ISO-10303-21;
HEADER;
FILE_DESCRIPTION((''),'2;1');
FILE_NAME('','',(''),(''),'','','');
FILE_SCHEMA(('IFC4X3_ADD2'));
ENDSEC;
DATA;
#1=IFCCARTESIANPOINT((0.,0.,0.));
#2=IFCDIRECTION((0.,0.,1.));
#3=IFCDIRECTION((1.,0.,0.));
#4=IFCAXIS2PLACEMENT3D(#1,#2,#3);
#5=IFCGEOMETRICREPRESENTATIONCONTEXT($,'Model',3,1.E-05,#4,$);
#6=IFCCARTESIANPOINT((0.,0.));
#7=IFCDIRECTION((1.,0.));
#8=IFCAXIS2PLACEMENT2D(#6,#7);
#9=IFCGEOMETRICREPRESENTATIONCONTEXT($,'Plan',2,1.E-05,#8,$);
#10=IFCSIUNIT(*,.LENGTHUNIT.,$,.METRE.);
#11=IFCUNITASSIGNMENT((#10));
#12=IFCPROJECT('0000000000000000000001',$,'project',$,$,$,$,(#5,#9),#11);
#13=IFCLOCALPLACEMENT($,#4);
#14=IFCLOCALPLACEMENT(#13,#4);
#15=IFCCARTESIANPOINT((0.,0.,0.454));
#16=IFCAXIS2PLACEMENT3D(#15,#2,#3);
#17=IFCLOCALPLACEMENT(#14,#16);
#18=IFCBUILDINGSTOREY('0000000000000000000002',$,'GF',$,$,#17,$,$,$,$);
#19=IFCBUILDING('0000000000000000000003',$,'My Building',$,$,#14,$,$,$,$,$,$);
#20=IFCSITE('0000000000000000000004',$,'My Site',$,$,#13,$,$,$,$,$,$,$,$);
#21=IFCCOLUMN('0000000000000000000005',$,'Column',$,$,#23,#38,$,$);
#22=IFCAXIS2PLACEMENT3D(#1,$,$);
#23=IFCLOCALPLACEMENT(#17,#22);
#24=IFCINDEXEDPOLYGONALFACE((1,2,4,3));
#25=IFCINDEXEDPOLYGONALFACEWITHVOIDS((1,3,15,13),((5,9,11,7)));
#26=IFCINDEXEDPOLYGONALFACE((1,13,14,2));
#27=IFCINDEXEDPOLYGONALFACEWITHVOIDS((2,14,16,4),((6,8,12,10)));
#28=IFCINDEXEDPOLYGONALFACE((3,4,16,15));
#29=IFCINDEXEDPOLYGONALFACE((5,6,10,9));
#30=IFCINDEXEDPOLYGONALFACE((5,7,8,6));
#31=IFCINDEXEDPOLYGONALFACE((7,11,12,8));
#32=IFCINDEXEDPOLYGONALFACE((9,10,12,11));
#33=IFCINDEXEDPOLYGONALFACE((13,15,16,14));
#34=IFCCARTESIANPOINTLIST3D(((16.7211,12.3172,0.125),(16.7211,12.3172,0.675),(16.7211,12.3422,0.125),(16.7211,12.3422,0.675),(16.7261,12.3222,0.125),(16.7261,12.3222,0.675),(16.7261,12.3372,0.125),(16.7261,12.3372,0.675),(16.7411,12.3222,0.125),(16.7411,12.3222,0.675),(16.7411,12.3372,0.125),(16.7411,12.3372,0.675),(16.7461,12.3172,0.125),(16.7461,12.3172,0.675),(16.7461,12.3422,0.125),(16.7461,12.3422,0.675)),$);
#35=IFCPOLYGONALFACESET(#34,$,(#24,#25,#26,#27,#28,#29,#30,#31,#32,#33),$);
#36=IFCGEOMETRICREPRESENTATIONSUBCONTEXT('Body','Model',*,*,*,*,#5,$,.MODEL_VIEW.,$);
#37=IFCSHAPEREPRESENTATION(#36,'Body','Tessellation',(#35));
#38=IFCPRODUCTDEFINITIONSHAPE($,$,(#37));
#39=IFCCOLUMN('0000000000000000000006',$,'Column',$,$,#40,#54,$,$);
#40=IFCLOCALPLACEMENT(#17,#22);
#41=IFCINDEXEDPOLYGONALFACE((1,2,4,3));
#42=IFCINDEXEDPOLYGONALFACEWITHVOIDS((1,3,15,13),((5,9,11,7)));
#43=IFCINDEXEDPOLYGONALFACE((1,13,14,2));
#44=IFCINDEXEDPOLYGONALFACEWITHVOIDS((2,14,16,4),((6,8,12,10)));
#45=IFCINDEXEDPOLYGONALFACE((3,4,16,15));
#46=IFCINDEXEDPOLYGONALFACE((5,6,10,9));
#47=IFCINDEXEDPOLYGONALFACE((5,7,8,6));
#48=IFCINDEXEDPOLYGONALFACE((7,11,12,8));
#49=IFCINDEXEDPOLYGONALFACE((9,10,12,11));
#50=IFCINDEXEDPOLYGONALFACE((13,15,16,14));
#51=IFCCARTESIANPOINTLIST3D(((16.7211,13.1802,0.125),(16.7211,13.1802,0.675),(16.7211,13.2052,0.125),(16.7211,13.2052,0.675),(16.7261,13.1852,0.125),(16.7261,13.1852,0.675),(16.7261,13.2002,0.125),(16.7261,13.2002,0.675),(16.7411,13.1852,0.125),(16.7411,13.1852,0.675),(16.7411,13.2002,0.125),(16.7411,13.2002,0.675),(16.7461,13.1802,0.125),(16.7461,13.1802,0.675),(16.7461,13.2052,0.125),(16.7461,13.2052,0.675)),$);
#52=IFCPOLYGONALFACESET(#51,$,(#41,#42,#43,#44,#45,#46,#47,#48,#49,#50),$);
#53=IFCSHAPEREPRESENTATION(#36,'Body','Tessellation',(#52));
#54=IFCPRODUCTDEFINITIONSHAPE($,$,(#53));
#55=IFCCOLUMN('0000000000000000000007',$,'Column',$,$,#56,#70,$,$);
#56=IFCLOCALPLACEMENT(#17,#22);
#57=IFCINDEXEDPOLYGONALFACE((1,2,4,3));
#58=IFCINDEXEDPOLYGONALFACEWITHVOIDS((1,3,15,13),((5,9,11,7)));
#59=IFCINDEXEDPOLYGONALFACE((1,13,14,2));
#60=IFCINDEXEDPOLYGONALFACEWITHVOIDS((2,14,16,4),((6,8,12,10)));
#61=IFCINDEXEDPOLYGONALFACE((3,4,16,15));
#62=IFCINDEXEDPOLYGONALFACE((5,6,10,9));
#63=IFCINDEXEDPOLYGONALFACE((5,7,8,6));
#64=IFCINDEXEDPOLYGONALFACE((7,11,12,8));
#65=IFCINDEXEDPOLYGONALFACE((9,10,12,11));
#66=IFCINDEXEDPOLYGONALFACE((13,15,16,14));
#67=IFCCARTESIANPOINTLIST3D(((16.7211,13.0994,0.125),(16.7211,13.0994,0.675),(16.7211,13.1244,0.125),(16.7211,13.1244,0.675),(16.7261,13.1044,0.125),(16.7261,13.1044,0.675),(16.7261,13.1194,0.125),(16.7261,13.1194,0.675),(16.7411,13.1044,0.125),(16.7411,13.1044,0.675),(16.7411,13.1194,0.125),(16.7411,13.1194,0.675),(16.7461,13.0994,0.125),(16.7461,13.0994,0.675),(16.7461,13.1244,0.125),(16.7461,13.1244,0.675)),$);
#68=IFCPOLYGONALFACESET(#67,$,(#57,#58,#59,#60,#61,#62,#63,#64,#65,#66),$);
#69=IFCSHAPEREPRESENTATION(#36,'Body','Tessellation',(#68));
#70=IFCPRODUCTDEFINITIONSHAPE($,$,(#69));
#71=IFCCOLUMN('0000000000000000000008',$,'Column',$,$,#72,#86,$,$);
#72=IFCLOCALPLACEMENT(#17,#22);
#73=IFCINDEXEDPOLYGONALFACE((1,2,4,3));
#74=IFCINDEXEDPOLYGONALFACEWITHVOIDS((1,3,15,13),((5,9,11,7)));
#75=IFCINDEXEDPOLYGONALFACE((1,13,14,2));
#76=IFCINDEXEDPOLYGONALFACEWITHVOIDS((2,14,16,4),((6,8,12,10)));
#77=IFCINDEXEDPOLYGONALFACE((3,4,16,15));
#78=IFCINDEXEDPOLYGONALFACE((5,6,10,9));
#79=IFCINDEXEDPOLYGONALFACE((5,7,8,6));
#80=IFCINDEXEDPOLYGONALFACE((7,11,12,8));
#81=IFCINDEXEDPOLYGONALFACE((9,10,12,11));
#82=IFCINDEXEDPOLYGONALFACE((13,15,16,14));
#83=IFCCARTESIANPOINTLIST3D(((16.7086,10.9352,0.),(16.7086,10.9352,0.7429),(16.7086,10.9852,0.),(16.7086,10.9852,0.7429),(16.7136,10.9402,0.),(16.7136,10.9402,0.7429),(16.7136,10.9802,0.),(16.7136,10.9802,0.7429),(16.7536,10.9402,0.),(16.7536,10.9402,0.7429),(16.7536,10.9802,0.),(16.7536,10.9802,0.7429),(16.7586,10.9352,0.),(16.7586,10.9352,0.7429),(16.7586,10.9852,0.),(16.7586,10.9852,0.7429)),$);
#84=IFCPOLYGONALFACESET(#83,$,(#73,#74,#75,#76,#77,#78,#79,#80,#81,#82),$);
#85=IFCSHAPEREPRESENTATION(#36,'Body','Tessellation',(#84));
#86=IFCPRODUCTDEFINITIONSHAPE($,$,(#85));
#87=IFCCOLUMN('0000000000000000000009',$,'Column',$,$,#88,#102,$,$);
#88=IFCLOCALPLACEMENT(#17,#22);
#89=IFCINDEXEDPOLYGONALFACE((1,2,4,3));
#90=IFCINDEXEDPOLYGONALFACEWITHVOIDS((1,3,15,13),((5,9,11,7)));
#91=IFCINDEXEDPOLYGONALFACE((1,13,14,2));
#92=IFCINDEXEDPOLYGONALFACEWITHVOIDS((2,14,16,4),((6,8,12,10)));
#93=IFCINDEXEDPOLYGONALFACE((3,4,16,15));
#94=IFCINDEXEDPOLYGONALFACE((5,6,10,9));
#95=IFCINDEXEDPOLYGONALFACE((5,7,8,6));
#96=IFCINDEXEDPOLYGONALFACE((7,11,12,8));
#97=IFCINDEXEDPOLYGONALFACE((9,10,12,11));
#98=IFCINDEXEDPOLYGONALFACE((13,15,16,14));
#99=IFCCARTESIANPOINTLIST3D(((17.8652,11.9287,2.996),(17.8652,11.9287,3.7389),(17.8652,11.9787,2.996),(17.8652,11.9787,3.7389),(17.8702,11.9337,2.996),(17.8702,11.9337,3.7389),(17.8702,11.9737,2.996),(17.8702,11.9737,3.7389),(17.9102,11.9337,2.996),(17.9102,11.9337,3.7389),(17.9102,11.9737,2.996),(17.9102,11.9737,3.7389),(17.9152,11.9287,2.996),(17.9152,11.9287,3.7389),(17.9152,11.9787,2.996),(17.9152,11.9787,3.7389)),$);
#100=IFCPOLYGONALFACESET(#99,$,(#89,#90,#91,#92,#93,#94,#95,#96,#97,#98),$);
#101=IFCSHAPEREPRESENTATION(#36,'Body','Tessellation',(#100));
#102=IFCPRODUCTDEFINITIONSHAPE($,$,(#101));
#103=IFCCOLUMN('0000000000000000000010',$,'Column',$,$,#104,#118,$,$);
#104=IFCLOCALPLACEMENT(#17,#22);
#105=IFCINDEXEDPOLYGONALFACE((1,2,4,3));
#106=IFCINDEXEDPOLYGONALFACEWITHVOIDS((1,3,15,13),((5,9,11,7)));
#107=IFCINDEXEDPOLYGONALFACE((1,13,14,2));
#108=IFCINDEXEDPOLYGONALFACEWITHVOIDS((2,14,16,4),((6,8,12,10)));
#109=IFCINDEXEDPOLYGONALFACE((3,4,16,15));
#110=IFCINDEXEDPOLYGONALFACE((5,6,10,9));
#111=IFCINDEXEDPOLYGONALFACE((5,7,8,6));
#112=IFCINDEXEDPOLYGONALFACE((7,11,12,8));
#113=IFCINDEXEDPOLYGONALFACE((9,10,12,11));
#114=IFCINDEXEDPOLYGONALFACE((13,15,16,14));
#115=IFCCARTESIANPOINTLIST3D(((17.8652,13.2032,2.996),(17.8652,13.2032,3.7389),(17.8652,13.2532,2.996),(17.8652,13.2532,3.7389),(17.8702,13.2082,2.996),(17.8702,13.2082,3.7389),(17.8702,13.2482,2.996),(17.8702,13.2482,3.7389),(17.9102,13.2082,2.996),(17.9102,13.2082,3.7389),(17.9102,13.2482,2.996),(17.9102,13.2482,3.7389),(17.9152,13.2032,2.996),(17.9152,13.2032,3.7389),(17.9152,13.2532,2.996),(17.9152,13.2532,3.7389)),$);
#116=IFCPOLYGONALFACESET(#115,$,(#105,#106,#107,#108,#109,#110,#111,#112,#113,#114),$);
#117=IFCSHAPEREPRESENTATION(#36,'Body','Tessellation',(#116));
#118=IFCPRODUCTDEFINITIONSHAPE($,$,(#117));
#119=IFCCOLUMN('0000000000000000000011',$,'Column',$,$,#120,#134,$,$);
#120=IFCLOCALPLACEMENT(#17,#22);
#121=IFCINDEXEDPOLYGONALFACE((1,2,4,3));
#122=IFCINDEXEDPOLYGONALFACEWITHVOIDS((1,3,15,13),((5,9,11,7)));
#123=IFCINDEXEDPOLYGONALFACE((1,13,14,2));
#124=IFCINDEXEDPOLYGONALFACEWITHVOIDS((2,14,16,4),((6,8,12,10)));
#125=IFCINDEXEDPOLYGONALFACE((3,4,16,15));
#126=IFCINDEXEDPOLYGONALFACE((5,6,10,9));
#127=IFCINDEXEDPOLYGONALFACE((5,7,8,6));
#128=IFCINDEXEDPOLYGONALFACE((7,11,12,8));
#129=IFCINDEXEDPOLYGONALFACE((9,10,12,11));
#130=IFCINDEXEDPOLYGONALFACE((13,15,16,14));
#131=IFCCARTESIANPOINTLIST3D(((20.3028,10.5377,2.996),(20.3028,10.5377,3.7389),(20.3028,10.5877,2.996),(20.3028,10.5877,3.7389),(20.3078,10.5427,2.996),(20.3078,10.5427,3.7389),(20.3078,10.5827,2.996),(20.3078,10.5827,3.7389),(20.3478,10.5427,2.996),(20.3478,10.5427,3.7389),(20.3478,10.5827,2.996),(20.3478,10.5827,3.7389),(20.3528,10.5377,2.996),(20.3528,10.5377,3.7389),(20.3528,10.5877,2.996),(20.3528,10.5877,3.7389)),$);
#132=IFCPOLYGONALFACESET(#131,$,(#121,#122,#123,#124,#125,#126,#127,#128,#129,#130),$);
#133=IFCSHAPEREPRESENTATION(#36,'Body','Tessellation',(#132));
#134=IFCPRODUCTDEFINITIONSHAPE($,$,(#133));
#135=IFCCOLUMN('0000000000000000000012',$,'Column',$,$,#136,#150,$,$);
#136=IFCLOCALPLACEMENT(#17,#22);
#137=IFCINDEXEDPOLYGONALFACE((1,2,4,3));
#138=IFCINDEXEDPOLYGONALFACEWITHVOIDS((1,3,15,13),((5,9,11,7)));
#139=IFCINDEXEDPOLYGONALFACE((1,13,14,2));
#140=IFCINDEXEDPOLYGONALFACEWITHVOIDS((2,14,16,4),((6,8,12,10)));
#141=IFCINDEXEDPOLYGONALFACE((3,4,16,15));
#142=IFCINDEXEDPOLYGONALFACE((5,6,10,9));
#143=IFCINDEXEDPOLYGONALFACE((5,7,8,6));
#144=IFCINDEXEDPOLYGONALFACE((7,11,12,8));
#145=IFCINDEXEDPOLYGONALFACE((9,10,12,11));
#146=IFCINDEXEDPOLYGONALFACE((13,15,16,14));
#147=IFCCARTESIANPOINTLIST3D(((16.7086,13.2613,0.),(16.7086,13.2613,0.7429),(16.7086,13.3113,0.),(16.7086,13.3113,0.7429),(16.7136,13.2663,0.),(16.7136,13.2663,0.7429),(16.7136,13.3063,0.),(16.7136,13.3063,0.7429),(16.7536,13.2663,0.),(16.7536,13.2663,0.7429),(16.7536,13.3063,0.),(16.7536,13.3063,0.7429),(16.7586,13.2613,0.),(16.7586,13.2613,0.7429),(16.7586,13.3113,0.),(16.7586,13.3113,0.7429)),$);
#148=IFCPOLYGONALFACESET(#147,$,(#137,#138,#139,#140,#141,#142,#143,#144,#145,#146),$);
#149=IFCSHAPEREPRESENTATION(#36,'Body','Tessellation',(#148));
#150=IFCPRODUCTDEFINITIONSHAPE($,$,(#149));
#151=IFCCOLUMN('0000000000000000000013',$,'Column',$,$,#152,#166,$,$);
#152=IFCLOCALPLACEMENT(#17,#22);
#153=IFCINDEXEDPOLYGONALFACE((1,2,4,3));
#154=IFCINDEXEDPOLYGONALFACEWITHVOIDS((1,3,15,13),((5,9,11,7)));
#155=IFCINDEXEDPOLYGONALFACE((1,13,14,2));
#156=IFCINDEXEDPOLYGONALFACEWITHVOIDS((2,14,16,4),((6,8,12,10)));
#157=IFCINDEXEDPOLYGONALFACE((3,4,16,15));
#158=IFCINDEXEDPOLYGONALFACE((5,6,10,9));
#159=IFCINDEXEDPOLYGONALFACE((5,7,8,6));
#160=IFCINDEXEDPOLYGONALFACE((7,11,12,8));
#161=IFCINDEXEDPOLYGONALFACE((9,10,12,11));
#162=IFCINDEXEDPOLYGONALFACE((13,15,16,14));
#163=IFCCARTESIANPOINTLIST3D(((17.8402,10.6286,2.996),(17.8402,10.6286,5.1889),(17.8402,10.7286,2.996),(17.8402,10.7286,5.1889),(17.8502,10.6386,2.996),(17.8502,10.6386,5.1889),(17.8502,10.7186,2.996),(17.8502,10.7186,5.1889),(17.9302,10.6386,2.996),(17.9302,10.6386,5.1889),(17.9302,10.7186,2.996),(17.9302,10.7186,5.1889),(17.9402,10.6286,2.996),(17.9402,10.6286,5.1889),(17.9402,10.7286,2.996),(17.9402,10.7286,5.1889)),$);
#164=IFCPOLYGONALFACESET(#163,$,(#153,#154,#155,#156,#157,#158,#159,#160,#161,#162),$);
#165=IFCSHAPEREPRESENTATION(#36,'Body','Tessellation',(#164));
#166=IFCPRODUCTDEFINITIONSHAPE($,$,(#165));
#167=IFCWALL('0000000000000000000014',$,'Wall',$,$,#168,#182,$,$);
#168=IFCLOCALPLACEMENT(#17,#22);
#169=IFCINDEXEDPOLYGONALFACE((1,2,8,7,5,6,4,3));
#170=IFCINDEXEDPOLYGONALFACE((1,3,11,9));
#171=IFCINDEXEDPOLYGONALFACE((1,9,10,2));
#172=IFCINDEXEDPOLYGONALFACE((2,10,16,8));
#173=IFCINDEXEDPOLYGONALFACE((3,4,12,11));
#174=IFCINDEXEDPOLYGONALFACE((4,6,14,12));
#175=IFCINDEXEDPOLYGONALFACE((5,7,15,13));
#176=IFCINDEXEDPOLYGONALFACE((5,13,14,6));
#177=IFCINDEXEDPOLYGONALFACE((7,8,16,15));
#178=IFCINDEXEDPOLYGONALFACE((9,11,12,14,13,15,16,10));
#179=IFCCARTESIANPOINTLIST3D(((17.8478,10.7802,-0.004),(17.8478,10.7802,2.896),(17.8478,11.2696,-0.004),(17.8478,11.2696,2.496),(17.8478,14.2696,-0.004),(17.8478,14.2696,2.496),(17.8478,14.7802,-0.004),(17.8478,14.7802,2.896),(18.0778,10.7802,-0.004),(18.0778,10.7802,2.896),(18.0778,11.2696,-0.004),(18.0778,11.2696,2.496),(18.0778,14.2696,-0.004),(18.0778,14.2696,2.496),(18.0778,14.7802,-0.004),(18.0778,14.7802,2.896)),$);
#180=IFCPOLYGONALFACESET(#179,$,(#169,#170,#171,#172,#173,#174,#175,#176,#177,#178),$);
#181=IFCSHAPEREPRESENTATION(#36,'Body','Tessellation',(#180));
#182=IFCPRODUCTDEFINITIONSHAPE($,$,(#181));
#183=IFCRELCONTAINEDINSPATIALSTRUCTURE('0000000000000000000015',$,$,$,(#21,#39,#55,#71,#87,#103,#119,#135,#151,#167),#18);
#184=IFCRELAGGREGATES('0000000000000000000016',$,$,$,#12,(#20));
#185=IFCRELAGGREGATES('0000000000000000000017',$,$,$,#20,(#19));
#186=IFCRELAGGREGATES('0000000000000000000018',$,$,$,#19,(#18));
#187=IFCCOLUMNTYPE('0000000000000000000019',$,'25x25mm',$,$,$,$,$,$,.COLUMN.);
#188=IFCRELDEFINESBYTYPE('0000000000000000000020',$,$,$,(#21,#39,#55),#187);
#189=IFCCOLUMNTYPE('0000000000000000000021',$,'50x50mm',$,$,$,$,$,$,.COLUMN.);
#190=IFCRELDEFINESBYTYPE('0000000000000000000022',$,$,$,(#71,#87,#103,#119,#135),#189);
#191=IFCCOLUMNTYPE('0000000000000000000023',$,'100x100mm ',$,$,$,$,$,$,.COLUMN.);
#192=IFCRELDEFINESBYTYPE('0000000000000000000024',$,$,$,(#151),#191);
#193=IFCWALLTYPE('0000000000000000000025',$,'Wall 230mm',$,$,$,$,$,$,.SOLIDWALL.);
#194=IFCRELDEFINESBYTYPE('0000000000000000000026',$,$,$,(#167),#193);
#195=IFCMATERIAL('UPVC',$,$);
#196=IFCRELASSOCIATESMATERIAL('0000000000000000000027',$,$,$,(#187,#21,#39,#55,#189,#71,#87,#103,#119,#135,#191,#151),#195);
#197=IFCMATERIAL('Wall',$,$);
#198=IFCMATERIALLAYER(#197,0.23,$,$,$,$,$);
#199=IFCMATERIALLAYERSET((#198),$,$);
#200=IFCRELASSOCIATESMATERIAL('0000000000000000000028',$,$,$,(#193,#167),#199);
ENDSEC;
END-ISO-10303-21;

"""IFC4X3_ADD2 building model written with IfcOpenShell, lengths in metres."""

from ifc_helpers import new_model, si_unit, frame, origin_with_axes, origin_2d_with_axis, place, context, subcontext, project, spatial, line, indexed_curve, hollow_rectangle, outline, extrude, source, transform, mapped, material, layer, layer_set, layer_usage, material_profile, profile_set, profile_usage, type_object, element, save


model = new_model("IFC4X3_ADD2")

# Units and contexts
model_context = context("Model", 3, precision=1e-05, world=origin_with_axes())
plan_context = context("Plan", 2, precision=1e-05, world=origin_2d_with_axis())
body_context = subcontext(model_context, "Body", "Model", "MODEL_VIEW")
ifc_project = project(units=[si_unit("LENGTHUNIT", "METRE")], contexts=[model_context, plan_context])

# Site, building, storey
site_placement = place(None, origin_with_axes())
site = spatial("IfcSite", under=ifc_project, at=site_placement, Name="My Site")
building_placement = place(site_placement, origin_with_axes())
building = spatial("IfcBuilding", under=site, at=building_placement, Name="My Building")
storey_placement = place(building_placement, frame((0.0, 0.0, 0.454), z_axis=(0.0, 0.0, 1.0), x_axis=(1.0, 0.0, 0.0)))
storey = spatial("IfcBuildingStorey", under=building, at=storey_placement, Name="GF")

# Columns
ifc_material_1 = material(Name="UPVC")
ifc_material_profile_1 = material_profile(ifc_material_1, hollow_rectangle(XDim=0.025, YDim=0.025, WallThickness=0.005))
ifc_profile_set_1 = profile_set([ifc_material_profile_1])
column_type_1 = type_object("IfcColumnType", Name="25x25mm", PredefinedType="COLUMN", material=ifc_profile_set_1)
ifc_profile_usage_1 = profile_usage(ifc_profile_set_1)
column_1_placement = place(storey_placement, frame((16.7336, 12.3297, 0.125), z_axis=(0.0, 0.0, 1.0), x_axis=(0.0, -1.0, 0.0)))
element("IfcColumn", 1, at=column_1_placement, inside=storey, type_object=column_type_1, material=ifc_profile_usage_1, Name="Column", context=body_context, shape_type="SweptSolid", body=[
    extrude(hollow_rectangle(XDim=0.025, YDim=0.025, WallThickness=0.005), origin_with_axes(), (0.0, 0.0, 1.0), 0.55),
])
ifc_profile_usage_2 = profile_usage(ifc_profile_set_1)
column_2_placement = place(storey_placement, frame((16.7336, 13.1927, 0.125), z_axis=(0.0, 0.0, 1.0), x_axis=(0.0, -1.0, 0.0)))
element("IfcColumn", 2, at=column_2_placement, inside=storey, type_object=column_type_1, material=ifc_profile_usage_2, Name="Column", context=body_context, shape_type="SweptSolid", body=[
    extrude(hollow_rectangle(XDim=0.025, YDim=0.025, WallThickness=0.005), origin_with_axes(), (0.0, 0.0, 1.0), 0.55),
])
ifc_profile_usage_3 = profile_usage(ifc_profile_set_1)
column_3_placement = place(storey_placement, frame((16.7336, 13.1119, 0.125), z_axis=(0.0, 0.0, 1.0), x_axis=(0.0, -1.0, 0.0)))
element("IfcColumn", 3, at=column_3_placement, inside=storey, type_object=column_type_1, material=ifc_profile_usage_3, Name="Column", context=body_context, shape_type="SweptSolid", body=[
    extrude(hollow_rectangle(XDim=0.025, YDim=0.025, WallThickness=0.005), origin_with_axes(), (0.0, 0.0, 1.0), 0.55),
])
ifc_material_profile_2 = material_profile(ifc_material_1, hollow_rectangle(XDim=0.05, YDim=0.05, WallThickness=0.005))
ifc_profile_set_2 = profile_set([ifc_material_profile_2])
ifc_profile_usage_4 = profile_usage(ifc_profile_set_2)
column_type_2 = type_object("IfcColumnType", Name="50x50mm", PredefinedType="COLUMN", material=ifc_profile_set_2)
column_4_placement = place(storey_placement, frame((16.7336, 10.9602, 0.0), z_axis=(0.0, 0.0, 1.0), x_axis=(0.0, -1.0, 0.0)))
element("IfcColumn", 4, at=column_4_placement, inside=storey, type_object=column_type_2, material=ifc_profile_usage_4, Name="Column", context=body_context, shape_type="SweptSolid", body=[
    extrude(hollow_rectangle(XDim=0.05, YDim=0.05, WallThickness=0.005), origin_with_axes(), (0.0, 0.0, 1.0), 0.7429),
])
ifc_profile_usage_5 = profile_usage(ifc_profile_set_2)
column_5_placement = place(storey_placement, frame((17.8902, 11.9537, 2.996), z_axis=(0.0, 0.0, 1.0), x_axis=(0.0, -1.0, 0.0)))
element("IfcColumn", 5, at=column_5_placement, inside=storey, type_object=column_type_2, material=ifc_profile_usage_5, Name="Column", context=body_context, shape_type="SweptSolid", body=[
    extrude(hollow_rectangle(XDim=0.05, YDim=0.05, WallThickness=0.005), origin_with_axes(), (0.0, 0.0, 1.0), 0.7429),
])
ifc_profile_usage_6 = profile_usage(ifc_profile_set_2)
column_6_placement = place(storey_placement, frame((17.8902, 13.2282, 2.996), z_axis=(0.0, 0.0, 1.0), x_axis=(0.0, -1.0, 0.0)))
element("IfcColumn", 6, at=column_6_placement, inside=storey, type_object=column_type_2, material=ifc_profile_usage_6, Name="Column", context=body_context, shape_type="SweptSolid", body=[
    extrude(hollow_rectangle(XDim=0.05, YDim=0.05, WallThickness=0.005), origin_with_axes(), (0.0, 0.0, 1.0), 0.7429),
])
ifc_profile_usage_7 = profile_usage(ifc_profile_set_2)
column_7_placement = place(storey_placement, frame((20.3278, 10.5627, 2.996), z_axis=(0.0, 0.0, 1.0), x_axis=(1.0, 0.0, 0.0)))
element("IfcColumn", 7, at=column_7_placement, inside=storey, type_object=column_type_2, material=ifc_profile_usage_7, Name="Column", context=body_context, shape_type="SweptSolid", body=[
    extrude(hollow_rectangle(XDim=0.05, YDim=0.05, WallThickness=0.005), origin_with_axes(), (0.0, 0.0, 1.0), 0.7429),
])
ifc_profile_usage_8 = profile_usage(ifc_profile_set_2)
column_8_placement = place(storey_placement, frame((16.7336, 13.2863, 0.0), z_axis=(0.0, 0.0, 1.0), x_axis=(0.0, -1.0, 0.0)))
element("IfcColumn", 8, at=column_8_placement, inside=storey, type_object=column_type_2, material=ifc_profile_usage_8, Name="Column", context=body_context, shape_type="SweptSolid", body=[
    extrude(hollow_rectangle(XDim=0.05, YDim=0.05, WallThickness=0.005), origin_with_axes(), (0.0, 0.0, 1.0), 0.7429),
])
ifc_material_profile_3 = material_profile(ifc_material_1, hollow_rectangle(XDim=0.1, YDim=0.1, WallThickness=0.01))
ifc_profile_set_3 = profile_set([ifc_material_profile_3])
ifc_profile_usage_9 = profile_usage(ifc_profile_set_3)
column_type_3 = type_object("IfcColumnType", Name="100x100mm ", PredefinedType="COLUMN", material=ifc_profile_set_3)
column_9_placement = place(storey_placement, frame((17.8902, 10.6786, 2.996), z_axis=(0.0, 0.0, 1.0), x_axis=(0.0, -1.0, 0.0)))
element("IfcColumn", 9, at=column_9_placement, inside=storey, type_object=column_type_3, material=ifc_profile_usage_9, Name="Column", context=body_context, shape_type="SweptSolid", body=[
    extrude(hollow_rectangle(XDim=0.1, YDim=0.1, WallThickness=0.01), origin_with_axes(), (0.0, 0.0, 1.0), 2.1929),
])

# Wall, opening
ifc_material_2 = material(Name="Wall")
ifc_layer = layer(ifc_material_2, 0.23)
ifc_layer_set = layer_set([ifc_layer])
ifc_layer_usage = layer_usage(ifc_layer_set, "AXIS2", "POSITIVE", 0.0)
wall_type = type_object("IfcWallType", Name="Wall 230mm", PredefinedType="SOLIDWALL", material=ifc_layer_set)
wall_placement = place(storey_placement, frame((18.0778, 10.7802, -0.004), z_axis=(0.0, 0.0, 1.0), x_axis=(0.000001, 1.0, 0.0)))
wall = element("IfcWall", 10, at=wall_placement, inside=storey, type_object=wall_type, material=ifc_layer_usage, Name="Wall", context=body_context, shape_type="SweptSolid", body=[
    extrude(outline(indexed_curve([(0.0, 0.0), (0.0, 0.23), (4.0, 0.23), (4.0, 0.0), (0.0, 0.0)], self_intersect=False)), origin_with_axes(), (0.0, 0.0, 1.0), 2.9),
])
shared_shape = source(origin_with_axes(), body_context, "Body", "SweptSolid", [
    extrude(outline(indexed_curve([(0.0, 0.0), (3.0, 0.0), (3.0, 2.5), (0.0, 2.5)], segments=[line(1, 2, 3, 4, 1)])), frame((0.0, -0.6, 0.0), z_axis=(0.0, -1.0, 0.0), x_axis=(1.0, 0.0, 0.0)), (0.0, 0.0, -1.0), 1.2),
])
opening_placement = place(wall_placement, frame((0.4894, 0.0, 0.0), z_axis=(0.0, 0.0, 1.0), x_axis=(1.0, 0.0, 0.0)))
element("IfcOpeningElement", 11, at=opening_placement, cuts=wall, PredefinedType="OPENING", context=body_context, shape_type="MappedRepresentation", body=[
    mapped(shared_shape, transform((0.0, 0.0, 0.0), x_axis=(1.0, 0.0, 0.0), y_axis=(0.0, 1.0, 0.0), z_axis=(0.0, 0.0, 1.0), scale=1.0)),
])

save(model, "model.ifc")
